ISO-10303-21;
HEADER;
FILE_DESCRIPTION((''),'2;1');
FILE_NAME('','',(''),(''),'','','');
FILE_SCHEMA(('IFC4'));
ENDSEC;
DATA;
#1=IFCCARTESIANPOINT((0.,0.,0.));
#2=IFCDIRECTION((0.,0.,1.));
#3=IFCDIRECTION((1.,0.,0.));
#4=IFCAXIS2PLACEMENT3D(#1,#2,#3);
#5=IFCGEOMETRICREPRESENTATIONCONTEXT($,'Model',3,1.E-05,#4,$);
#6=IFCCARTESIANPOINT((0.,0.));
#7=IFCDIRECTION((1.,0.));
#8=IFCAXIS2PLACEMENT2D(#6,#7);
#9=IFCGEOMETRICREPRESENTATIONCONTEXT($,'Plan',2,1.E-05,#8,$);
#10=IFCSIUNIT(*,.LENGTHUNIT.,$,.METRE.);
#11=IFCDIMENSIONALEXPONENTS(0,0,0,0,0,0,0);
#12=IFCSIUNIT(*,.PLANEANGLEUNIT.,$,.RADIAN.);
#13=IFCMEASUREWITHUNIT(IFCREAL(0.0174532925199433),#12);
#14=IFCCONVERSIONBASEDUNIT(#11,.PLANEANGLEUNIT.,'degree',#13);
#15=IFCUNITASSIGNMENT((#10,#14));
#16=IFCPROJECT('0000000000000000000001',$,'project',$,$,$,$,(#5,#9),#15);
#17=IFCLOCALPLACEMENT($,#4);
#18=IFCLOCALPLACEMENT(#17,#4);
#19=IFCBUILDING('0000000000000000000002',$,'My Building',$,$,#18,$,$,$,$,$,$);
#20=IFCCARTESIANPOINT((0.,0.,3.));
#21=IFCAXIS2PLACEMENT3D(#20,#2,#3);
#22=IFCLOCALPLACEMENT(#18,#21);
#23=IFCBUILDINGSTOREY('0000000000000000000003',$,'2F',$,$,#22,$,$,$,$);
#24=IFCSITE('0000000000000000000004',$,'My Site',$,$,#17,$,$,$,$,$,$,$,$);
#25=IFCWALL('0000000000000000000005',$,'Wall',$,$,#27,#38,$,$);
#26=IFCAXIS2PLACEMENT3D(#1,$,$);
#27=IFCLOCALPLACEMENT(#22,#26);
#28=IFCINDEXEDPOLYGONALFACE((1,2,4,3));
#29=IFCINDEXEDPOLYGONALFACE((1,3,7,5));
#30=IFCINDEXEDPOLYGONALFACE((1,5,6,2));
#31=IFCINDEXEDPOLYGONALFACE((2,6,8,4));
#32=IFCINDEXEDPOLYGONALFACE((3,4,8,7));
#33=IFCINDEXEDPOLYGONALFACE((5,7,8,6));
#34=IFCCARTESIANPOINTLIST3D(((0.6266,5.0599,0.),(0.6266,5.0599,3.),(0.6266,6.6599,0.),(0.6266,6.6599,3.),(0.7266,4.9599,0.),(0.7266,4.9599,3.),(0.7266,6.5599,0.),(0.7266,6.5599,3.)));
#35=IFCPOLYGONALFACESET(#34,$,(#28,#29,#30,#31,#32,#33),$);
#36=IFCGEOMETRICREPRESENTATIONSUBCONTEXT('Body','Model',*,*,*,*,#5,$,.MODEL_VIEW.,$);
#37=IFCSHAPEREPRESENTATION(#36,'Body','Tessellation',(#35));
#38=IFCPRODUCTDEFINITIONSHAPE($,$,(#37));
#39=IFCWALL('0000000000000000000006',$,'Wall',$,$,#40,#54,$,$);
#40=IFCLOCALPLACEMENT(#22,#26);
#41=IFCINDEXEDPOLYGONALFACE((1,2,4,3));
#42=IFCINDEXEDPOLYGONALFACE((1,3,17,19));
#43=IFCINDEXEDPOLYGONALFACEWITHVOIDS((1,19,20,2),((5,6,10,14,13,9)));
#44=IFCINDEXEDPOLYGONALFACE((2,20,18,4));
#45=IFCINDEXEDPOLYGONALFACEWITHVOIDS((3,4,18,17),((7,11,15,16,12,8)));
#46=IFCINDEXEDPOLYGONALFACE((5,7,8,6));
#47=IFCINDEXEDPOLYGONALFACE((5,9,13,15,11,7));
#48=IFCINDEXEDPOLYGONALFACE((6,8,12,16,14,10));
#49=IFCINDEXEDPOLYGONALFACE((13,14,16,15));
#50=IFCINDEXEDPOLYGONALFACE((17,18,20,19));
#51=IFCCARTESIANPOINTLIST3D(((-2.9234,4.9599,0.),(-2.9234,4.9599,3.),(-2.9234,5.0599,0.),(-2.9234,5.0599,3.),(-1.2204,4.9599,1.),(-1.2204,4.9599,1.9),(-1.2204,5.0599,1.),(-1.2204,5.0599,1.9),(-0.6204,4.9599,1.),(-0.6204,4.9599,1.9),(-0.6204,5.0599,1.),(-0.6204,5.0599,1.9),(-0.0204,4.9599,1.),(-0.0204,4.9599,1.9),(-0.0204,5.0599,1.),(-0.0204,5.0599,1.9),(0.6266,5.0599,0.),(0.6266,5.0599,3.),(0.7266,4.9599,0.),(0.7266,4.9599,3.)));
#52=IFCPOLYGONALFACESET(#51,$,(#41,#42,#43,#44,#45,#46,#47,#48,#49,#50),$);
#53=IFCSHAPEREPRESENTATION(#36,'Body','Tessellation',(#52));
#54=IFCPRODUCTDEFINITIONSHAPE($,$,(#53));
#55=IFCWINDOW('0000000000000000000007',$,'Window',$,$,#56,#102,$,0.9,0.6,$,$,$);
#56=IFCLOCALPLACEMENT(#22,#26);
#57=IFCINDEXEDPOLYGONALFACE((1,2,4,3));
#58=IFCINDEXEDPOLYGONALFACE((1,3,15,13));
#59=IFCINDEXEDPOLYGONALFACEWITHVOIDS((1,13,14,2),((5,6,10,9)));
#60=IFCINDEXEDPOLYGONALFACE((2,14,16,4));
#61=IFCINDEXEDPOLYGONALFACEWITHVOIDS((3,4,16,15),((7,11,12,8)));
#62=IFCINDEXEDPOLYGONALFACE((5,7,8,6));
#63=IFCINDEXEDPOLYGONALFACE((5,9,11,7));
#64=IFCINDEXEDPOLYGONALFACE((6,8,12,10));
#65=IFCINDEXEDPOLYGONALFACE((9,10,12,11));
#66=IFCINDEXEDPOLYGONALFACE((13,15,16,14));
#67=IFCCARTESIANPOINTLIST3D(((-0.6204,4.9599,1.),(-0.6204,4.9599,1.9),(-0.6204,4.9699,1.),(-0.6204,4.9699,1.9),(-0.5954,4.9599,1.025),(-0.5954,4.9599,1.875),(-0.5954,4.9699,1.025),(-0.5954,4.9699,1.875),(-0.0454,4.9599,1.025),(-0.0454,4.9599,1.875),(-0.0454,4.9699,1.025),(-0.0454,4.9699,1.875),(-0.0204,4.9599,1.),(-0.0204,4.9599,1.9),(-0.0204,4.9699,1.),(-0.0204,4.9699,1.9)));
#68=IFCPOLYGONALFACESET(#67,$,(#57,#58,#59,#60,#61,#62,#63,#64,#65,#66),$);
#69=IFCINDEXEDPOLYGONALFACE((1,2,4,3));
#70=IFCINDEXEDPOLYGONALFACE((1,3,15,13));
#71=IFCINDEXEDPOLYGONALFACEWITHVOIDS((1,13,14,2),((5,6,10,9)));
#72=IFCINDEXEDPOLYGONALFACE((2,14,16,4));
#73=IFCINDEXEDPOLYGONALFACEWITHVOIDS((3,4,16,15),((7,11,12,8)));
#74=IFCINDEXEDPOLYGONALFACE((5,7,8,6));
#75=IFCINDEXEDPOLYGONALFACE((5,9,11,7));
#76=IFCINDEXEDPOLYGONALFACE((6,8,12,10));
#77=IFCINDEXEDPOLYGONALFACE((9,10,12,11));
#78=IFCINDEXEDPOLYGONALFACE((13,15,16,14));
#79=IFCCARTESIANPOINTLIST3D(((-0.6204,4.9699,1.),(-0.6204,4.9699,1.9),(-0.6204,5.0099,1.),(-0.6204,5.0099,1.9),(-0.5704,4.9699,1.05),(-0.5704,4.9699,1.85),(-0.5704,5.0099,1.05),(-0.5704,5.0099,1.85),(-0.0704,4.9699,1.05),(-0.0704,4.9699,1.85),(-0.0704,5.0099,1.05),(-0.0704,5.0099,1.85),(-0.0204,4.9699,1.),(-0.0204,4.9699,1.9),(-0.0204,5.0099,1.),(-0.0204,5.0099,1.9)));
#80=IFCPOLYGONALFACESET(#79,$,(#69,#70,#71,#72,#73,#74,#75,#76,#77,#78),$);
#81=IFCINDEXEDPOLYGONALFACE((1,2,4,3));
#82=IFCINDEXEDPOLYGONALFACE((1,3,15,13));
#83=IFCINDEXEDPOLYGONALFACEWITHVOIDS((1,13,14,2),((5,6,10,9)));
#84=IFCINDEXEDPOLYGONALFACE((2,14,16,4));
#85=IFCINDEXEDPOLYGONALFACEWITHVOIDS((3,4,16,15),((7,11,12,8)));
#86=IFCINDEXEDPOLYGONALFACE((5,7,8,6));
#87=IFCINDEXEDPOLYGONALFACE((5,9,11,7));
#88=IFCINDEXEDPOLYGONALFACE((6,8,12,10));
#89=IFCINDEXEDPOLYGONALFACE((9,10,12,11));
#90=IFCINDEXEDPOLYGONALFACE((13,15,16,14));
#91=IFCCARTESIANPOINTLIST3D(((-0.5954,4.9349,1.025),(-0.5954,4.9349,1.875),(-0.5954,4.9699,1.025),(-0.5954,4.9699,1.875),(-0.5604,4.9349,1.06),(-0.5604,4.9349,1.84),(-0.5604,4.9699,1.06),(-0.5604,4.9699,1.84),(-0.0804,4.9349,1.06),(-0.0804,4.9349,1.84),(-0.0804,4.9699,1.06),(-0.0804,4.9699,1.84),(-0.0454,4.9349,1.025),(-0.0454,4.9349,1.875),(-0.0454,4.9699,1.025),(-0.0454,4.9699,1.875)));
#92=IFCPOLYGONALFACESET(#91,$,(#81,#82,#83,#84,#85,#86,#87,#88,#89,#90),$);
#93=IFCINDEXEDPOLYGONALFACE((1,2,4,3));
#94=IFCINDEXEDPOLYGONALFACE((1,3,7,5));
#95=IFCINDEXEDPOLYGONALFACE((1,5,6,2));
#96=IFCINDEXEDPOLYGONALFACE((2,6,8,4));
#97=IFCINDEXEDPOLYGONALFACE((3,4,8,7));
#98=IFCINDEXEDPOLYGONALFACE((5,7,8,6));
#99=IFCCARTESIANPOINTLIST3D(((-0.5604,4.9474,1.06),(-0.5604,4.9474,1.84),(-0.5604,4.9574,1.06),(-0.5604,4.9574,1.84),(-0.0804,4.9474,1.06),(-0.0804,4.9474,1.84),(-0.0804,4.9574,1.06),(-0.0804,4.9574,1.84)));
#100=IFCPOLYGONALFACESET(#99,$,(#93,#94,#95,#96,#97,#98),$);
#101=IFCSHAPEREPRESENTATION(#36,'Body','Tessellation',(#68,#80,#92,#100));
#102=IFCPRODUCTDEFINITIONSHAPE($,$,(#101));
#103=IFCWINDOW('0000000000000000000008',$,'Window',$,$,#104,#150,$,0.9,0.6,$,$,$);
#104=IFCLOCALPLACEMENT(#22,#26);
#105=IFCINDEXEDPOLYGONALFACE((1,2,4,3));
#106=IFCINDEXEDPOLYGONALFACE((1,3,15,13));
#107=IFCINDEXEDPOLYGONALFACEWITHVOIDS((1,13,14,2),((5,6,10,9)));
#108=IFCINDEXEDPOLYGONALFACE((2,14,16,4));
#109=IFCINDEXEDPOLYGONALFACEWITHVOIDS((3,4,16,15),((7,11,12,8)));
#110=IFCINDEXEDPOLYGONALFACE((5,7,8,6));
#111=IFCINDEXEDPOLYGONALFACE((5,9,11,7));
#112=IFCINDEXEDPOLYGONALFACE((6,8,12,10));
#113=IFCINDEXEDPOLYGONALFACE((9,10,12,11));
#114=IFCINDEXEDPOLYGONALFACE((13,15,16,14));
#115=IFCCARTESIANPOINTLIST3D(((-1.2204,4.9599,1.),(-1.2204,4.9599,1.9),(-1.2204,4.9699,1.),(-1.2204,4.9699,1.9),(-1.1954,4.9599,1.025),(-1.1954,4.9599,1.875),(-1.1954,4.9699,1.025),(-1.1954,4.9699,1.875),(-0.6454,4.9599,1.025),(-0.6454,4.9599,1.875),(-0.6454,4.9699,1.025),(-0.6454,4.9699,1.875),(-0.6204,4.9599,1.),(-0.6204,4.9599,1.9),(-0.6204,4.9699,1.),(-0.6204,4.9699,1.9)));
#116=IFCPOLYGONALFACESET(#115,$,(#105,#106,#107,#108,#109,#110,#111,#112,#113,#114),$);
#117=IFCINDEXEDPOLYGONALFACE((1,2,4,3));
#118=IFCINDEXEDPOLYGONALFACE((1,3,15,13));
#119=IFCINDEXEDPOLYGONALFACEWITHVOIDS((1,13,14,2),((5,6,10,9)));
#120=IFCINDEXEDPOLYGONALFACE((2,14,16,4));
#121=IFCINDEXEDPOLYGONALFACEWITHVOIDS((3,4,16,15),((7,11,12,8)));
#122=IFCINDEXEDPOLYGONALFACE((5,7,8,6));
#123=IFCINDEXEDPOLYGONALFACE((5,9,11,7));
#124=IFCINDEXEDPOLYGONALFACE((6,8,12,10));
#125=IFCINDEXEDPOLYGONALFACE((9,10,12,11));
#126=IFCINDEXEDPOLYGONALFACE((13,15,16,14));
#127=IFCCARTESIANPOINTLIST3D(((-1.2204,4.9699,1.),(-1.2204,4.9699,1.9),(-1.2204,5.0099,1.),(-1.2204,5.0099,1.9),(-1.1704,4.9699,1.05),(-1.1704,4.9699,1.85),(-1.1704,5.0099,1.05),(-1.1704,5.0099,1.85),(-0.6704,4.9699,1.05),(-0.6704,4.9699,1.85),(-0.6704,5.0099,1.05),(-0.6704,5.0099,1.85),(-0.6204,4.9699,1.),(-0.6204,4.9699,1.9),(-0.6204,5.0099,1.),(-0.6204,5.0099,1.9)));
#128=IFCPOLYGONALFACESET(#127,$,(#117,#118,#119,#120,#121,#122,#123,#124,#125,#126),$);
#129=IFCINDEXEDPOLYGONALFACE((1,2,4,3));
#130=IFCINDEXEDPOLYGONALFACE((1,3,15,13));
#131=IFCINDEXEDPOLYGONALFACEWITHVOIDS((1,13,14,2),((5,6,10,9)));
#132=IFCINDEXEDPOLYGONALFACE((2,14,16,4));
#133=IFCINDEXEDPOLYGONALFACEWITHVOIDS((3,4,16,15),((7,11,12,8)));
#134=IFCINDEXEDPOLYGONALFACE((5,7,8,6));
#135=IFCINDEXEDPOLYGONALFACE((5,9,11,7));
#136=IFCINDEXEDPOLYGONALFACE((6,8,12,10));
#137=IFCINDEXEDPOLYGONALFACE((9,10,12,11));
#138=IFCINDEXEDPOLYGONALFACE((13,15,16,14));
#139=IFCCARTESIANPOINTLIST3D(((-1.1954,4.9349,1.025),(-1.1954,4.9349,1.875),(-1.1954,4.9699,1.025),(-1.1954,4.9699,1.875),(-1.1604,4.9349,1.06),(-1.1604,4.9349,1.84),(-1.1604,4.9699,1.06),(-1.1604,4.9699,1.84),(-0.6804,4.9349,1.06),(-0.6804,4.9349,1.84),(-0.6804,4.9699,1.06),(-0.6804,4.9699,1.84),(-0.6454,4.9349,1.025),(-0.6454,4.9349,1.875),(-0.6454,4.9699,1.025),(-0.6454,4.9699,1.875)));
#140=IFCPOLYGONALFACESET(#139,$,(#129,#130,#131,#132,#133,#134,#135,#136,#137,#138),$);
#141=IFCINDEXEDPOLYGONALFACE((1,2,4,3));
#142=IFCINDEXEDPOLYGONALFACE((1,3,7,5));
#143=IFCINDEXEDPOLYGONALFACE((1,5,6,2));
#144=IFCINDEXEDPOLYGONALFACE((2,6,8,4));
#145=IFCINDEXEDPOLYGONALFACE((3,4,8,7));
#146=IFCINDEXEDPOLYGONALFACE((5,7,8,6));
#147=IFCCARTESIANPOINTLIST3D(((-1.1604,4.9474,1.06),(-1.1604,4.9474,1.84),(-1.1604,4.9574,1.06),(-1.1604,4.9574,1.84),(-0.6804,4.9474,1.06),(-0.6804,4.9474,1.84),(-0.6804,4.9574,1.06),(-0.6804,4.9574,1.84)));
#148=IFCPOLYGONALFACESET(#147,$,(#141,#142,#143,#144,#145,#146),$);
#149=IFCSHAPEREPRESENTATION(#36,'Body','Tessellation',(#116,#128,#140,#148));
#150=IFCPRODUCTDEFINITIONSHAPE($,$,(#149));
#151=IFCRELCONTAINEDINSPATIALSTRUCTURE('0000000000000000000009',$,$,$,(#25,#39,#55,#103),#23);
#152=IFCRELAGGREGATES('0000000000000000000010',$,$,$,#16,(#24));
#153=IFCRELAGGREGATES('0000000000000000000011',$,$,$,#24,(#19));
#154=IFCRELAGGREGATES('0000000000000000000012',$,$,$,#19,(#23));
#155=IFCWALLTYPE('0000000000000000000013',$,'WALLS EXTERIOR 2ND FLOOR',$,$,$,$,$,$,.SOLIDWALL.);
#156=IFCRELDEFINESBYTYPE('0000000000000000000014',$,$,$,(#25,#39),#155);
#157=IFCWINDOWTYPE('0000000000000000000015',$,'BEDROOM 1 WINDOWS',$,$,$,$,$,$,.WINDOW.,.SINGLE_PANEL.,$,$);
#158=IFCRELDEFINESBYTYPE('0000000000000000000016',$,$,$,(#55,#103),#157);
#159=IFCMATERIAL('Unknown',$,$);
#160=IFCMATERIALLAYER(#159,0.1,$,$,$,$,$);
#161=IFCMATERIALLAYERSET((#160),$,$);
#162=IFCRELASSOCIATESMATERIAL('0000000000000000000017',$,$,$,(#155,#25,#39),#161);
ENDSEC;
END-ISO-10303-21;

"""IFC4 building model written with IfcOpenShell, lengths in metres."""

from ifc_helpers import new_model, entity, si_unit, converted_unit, frame, origin_with_axes, origin_2d_with_axis, place, context, subcontext, project, spatial, line, indexed_curve, outline, extrude, shape, source, transform, mapped, material, layer, layer_set, layer_usage, type_object, type_shapes, element, fill, save


model = new_model("IFC4")

# Units and contexts
model_context = context("Model", 3, precision=1e-05, world=origin_with_axes())
plan_context = context("Plan", 2, precision=1e-05, world=origin_2d_with_axis())
body_context_1 = subcontext(model_context, "Body", "Model", "MODEL_VIEW")
body_context_2 = subcontext(plan_context, "Body", "Plan", "PLAN_VIEW")
ifc_project = project(units=[si_unit("LENGTHUNIT", "METRE"), converted_unit("PLANEANGLEUNIT", "degree", entity("IfcReal", 0.0174532925199433), si_unit("PLANEANGLEUNIT", "RADIAN"), dimensions=[0, 0, 0, 0, 0, 0, 0])], contexts=[model_context, plan_context])

# Site, building, storey
site_placement = place(None, origin_with_axes())
site = spatial("IfcSite", under=ifc_project, at=site_placement, Name="My Site")
building_placement = place(site_placement, origin_with_axes())
building = spatial("IfcBuilding", under=site, at=building_placement, Name="My Building")
storey_placement = place(building_placement, frame((0.0, 0.0, 3.0), z_axis=(0.0, 0.0, 1.0), x_axis=(1.0, 0.0, 0.0)))
storey = spatial("IfcBuildingStorey", under=building, at=storey_placement, Name="2F")

# Shared definitions
ifc_material = material(Name="Unknown")

# Shared definitions
ifc_layer_1 = layer(ifc_material, 0.1)
ifc_layer_set_1 = layer_set([ifc_layer_1])
wall_type_1 = type_object("IfcWallType", Name="WALLS EXTERIOR 2ND FLOOR", PredefinedType="SOLIDWALL", material=ifc_layer_set_1)

# Wall
ifc_layer_usage_1 = layer_usage(ifc_layer_set_1, "AXIS2", "POSITIVE", 0.0)
wall_1_placement = place(storey_placement, frame((0.6266, 6.6599, 0.0), z_axis=(0.0, 0.0, 1.0), x_axis=(0.0, -1.0, 0.0)))
element("IfcWall", 1, at=wall_1_placement, inside=storey, type_object=wall_type_1, material=ifc_layer_usage_1, Name="Wall", context=body_context_1, shape_type="SweptSolid", body=[
    extrude(outline(indexed_curve([(0.0, 0.0), (0.1, 0.1), (1.7, 0.1), (1.6, 0.0)], segments=[line(1, 2, 3, 4, 1)])), origin_with_axes(), (0.0, 0.0, 1.0), 3.0),
])

# Wall, openings, windows
ifc_layer_usage_2 = layer_usage(ifc_layer_set_1, "AXIS2", "POSITIVE", 0.0)
wall_2_placement = place(storey_placement, frame((0.6266, 5.0599, 0.0), z_axis=(0.0, 0.0, 1.0), x_axis=(-1.0, 0.0, 0.0)))
wall_2 = element("IfcWall", 2, at=wall_2_placement, inside=storey, type_object=wall_type_1, material=ifc_layer_usage_2, Name="Wall", context=body_context_1, shape_type="SweptSolid", body=[
    extrude(outline(indexed_curve([(0.0, 0.0), (-0.1, 0.1), (3.55, 0.1), (3.55, 0.0)], segments=[line(1, 2, 3, 4, 1)])), origin_with_axes(), (0.0, 0.0, 1.0), 3.0),
])
shared_shape_1 = source(origin_with_axes(), body_context_1, "Body", "SweptSolid", [
    extrude(outline(indexed_curve([(0.0, 0.0), (0.6, 0.0), (0.6, 0.9), (0.0, 0.9)], segments=[line(1, 2, 3, 4, 1)])), frame((0.0, -0.6, 0.0), z_axis=(0.0, -1.0, 0.0), x_axis=(1.0, 0.0, 0.0)), (0.0, 0.0, -1.0), 1.2),
])
opening_1_placement = place(wall_2_placement, frame((0.647, 0.0, 1.0), z_axis=(0.0, 0.0, 1.0), x_axis=(1.0, 0.0, 0.0)))
opening_1 = element("IfcOpeningElement", 3, at=opening_1_placement, cuts=wall_2, PredefinedType="OPENING", context=body_context_1, shape_type="MappedRepresentation", body=[
    mapped(shared_shape_1, transform((0.0, 0.0, 0.0), x_axis=(1.0, 0.0, 0.0), y_axis=(0.0, 1.0, 0.0), z_axis=(0.0, 0.0, 1.0), scale=1.0)),
])
opening_2_placement = place(wall_2_placement, frame((1.247, 0.0, 1.0), z_axis=(0.0, 0.0, 1.0), x_axis=(1.0, 0.0, 0.0)))
opening_2 = element("IfcOpeningElement", 4, at=opening_2_placement, cuts=wall_2, PredefinedType="OPENING", context=body_context_1, shape_type="MappedRepresentation", body=[
    mapped(shared_shape_1, transform((0.0, 0.0, 0.0), x_axis=(1.0, 0.0, 0.0), y_axis=(0.0, 1.0, 0.0), z_axis=(0.0, 0.0, 1.0), scale=1.0)),
])
window_type_1 = type_object("IfcWindowType", Name="BEDROOM 1 WINDOWS", PartitioningType="SINGLE_PANEL", PredefinedType="WINDOW")
shared_shape_2 = source(origin_with_axes(), body_context_1, "Body", "SweptSolid", [
    extrude(outline(indexed_curve([(0.0, 0.0), (0.6, 0.0), (0.6, 0.9), (0.0, 0.9)], segments=[line(1, 2, 3, 4, 1)]), holes=[indexed_curve([(0.025, 0.025), (0.575, 0.025), (0.575, 0.875), (0.025, 0.875)], segments=[line(1, 2, 3, 4, 1)])]), frame((0.0, 0.09, 0.0), z_axis=(0.0, -1.0, 0.0), x_axis=(1.0, 0.0, 0.0)), (0.0, 0.0, -1.0), 0.01),
    extrude(outline(indexed_curve([(0.0, 0.0), (0.6, 0.0), (0.6, 0.9), (0.0, 0.9)], segments=[line(1, 2, 3, 4, 1)]), holes=[indexed_curve([(0.05, 0.05), (0.55, 0.05), (0.55, 0.85), (0.05, 0.85)], segments=[line(1, 2, 3, 4, 1)])]), frame((0.0, 0.05, 0.0), z_axis=(0.0, -1.0, 0.0), x_axis=(1.0, 0.0, 0.0)), (0.0, 0.0, -1.0), 0.04),
    extrude(outline(indexed_curve([(0.0, 0.0), (0.55, 0.0), (0.55, 0.85), (0.0, 0.85)], segments=[line(1, 2, 3, 4, 1)]), holes=[indexed_curve([(0.035, 0.035), (0.515, 0.035), (0.515, 0.815), (0.035, 0.815)], segments=[line(1, 2, 3, 4, 1)])]), frame((0.025, 0.09, 0.025), z_axis=(0.0, -1.0, 0.0), x_axis=(1.0, 0.0, 0.0)), (0.0, 0.0, -1.0), 0.035),
    extrude(outline(indexed_curve([(0.035, 0.035), (0.515, 0.035), (0.515, 0.815), (0.035, 0.815)], segments=[line(1, 2, 3, 4, 1)])), frame((0.025, 0.1025, 0.025), z_axis=(0.0, -1.0, 0.0), x_axis=(1.0, 0.0, 0.0)), (0.0, 0.0, -1.0), 0.01),
])
shared_shape_3 = source(origin_with_axes(), body_context_2, "Body", "Curve2D", [
    entity("IfcIndexedPolyCurve", entity("IfcCartesianPointList2D", [[0.05, 0.05], [0.55, 0.05]])),
    entity("IfcIndexedPolyCurve", entity("IfcCartesianPointList2D", [[0.0, 0.1], [0.025, 0.1], [0.025, 0.09], [0.05, 0.09], [0.05, 0.05], [0.0, 0.05]]), [entity("IfcLineIndex", [1, 2, 3, 4, 5, 6, 1])]),
    entity("IfcIndexedPolyCurve", entity("IfcCartesianPointList2D", [[0.6, 0.1], [0.575, 0.1], [0.575, 0.09], [0.55, 0.09], [0.55, 0.05], [0.6, 0.05]]), [entity("IfcLineIndex", [1, 2, 3, 4, 5, 6, 1])]),
    entity("IfcIndexedPolyCurve", entity("IfcCartesianPointList2D", [[0.025, 0.09], [0.06, 0.09], [0.06, 0.125], [0.025, 0.125]]), [entity("IfcLineIndex", [1, 2, 3, 4, 1])]),
    entity("IfcIndexedPolyCurve", entity("IfcCartesianPointList2D", [[0.575, 0.09], [0.54, 0.09], [0.54, 0.125], [0.575, 0.125]]), [entity("IfcLineIndex", [1, 2, 3, 4, 1])]),
    entity("IfcIndexedPolyCurve", entity("IfcCartesianPointList2D", [[0.06, 0.09], [0.54, 0.09]])),
    entity("IfcIndexedPolyCurve", entity("IfcCartesianPointList2D", [[0.06, 0.125], [0.54, 0.125]])),
    entity("IfcIndexedPolyCurve", entity("IfcCartesianPointList2D", [[0.06, 0.1075], [0.54, 0.1075]])),
])
type_shapes(window_type_1, [shared_shape_2, shared_shape_3])
window_1_placement = place(opening_1_placement, origin_with_axes())
window_1 = element("IfcWindow", 5, at=window_1_placement, inside=storey, type_object=window_type_1, Name="Window", OverallHeight=0.9, OverallWidth=0.6, shapes=[
    shape(body_context_1, "Body", "MappedRepresentation", [mapped(shared_shape_2, transform((0.0, 0.0, 0.0), x_axis=(1.0, 0.0, 0.0), y_axis=(0.0, 1.0, 0.0), z_axis=(0.0, 0.0, 1.0), scale=1.0))]),
    shape(body_context_2, "Body", "MappedRepresentation", [mapped(shared_shape_3, transform((0.0, 0.0, 0.0), x_axis=(1.0, 0.0, 0.0), y_axis=(0.0, 1.0, 0.0), z_axis=(0.0, 0.0, 1.0), scale=1.0))]),
])
fill(opening_1, window_1)
window_2_placement = place(opening_2_placement, frame((0.0, 0.0, 0.0), z_axis=(0.0, 0.0, 1.0), x_axis=(1.0, 0.0, 0.0)))
window_2 = element("IfcWindow", 6, at=window_2_placement, inside=storey, type_object=window_type_1, Name="Window", OverallHeight=0.9, OverallWidth=0.6, shapes=[
    shape(body_context_1, "Body", "MappedRepresentation", [mapped(shared_shape_2, transform((0.0, 0.0, 0.0), x_axis=(1.0, 0.0, 0.0), y_axis=(0.0, 1.0, 0.0), z_axis=(0.0, 0.0, 1.0), scale=1.0))]),
    shape(body_context_2, "Body", "MappedRepresentation", [mapped(shared_shape_3, transform((0.0, 0.0, 0.0), x_axis=(1.0, 0.0, 0.0), y_axis=(0.0, 1.0, 0.0), z_axis=(0.0, 0.0, 1.0), scale=1.0))]),
])
fill(opening_2, window_2)

save(model, "model.ifc")
